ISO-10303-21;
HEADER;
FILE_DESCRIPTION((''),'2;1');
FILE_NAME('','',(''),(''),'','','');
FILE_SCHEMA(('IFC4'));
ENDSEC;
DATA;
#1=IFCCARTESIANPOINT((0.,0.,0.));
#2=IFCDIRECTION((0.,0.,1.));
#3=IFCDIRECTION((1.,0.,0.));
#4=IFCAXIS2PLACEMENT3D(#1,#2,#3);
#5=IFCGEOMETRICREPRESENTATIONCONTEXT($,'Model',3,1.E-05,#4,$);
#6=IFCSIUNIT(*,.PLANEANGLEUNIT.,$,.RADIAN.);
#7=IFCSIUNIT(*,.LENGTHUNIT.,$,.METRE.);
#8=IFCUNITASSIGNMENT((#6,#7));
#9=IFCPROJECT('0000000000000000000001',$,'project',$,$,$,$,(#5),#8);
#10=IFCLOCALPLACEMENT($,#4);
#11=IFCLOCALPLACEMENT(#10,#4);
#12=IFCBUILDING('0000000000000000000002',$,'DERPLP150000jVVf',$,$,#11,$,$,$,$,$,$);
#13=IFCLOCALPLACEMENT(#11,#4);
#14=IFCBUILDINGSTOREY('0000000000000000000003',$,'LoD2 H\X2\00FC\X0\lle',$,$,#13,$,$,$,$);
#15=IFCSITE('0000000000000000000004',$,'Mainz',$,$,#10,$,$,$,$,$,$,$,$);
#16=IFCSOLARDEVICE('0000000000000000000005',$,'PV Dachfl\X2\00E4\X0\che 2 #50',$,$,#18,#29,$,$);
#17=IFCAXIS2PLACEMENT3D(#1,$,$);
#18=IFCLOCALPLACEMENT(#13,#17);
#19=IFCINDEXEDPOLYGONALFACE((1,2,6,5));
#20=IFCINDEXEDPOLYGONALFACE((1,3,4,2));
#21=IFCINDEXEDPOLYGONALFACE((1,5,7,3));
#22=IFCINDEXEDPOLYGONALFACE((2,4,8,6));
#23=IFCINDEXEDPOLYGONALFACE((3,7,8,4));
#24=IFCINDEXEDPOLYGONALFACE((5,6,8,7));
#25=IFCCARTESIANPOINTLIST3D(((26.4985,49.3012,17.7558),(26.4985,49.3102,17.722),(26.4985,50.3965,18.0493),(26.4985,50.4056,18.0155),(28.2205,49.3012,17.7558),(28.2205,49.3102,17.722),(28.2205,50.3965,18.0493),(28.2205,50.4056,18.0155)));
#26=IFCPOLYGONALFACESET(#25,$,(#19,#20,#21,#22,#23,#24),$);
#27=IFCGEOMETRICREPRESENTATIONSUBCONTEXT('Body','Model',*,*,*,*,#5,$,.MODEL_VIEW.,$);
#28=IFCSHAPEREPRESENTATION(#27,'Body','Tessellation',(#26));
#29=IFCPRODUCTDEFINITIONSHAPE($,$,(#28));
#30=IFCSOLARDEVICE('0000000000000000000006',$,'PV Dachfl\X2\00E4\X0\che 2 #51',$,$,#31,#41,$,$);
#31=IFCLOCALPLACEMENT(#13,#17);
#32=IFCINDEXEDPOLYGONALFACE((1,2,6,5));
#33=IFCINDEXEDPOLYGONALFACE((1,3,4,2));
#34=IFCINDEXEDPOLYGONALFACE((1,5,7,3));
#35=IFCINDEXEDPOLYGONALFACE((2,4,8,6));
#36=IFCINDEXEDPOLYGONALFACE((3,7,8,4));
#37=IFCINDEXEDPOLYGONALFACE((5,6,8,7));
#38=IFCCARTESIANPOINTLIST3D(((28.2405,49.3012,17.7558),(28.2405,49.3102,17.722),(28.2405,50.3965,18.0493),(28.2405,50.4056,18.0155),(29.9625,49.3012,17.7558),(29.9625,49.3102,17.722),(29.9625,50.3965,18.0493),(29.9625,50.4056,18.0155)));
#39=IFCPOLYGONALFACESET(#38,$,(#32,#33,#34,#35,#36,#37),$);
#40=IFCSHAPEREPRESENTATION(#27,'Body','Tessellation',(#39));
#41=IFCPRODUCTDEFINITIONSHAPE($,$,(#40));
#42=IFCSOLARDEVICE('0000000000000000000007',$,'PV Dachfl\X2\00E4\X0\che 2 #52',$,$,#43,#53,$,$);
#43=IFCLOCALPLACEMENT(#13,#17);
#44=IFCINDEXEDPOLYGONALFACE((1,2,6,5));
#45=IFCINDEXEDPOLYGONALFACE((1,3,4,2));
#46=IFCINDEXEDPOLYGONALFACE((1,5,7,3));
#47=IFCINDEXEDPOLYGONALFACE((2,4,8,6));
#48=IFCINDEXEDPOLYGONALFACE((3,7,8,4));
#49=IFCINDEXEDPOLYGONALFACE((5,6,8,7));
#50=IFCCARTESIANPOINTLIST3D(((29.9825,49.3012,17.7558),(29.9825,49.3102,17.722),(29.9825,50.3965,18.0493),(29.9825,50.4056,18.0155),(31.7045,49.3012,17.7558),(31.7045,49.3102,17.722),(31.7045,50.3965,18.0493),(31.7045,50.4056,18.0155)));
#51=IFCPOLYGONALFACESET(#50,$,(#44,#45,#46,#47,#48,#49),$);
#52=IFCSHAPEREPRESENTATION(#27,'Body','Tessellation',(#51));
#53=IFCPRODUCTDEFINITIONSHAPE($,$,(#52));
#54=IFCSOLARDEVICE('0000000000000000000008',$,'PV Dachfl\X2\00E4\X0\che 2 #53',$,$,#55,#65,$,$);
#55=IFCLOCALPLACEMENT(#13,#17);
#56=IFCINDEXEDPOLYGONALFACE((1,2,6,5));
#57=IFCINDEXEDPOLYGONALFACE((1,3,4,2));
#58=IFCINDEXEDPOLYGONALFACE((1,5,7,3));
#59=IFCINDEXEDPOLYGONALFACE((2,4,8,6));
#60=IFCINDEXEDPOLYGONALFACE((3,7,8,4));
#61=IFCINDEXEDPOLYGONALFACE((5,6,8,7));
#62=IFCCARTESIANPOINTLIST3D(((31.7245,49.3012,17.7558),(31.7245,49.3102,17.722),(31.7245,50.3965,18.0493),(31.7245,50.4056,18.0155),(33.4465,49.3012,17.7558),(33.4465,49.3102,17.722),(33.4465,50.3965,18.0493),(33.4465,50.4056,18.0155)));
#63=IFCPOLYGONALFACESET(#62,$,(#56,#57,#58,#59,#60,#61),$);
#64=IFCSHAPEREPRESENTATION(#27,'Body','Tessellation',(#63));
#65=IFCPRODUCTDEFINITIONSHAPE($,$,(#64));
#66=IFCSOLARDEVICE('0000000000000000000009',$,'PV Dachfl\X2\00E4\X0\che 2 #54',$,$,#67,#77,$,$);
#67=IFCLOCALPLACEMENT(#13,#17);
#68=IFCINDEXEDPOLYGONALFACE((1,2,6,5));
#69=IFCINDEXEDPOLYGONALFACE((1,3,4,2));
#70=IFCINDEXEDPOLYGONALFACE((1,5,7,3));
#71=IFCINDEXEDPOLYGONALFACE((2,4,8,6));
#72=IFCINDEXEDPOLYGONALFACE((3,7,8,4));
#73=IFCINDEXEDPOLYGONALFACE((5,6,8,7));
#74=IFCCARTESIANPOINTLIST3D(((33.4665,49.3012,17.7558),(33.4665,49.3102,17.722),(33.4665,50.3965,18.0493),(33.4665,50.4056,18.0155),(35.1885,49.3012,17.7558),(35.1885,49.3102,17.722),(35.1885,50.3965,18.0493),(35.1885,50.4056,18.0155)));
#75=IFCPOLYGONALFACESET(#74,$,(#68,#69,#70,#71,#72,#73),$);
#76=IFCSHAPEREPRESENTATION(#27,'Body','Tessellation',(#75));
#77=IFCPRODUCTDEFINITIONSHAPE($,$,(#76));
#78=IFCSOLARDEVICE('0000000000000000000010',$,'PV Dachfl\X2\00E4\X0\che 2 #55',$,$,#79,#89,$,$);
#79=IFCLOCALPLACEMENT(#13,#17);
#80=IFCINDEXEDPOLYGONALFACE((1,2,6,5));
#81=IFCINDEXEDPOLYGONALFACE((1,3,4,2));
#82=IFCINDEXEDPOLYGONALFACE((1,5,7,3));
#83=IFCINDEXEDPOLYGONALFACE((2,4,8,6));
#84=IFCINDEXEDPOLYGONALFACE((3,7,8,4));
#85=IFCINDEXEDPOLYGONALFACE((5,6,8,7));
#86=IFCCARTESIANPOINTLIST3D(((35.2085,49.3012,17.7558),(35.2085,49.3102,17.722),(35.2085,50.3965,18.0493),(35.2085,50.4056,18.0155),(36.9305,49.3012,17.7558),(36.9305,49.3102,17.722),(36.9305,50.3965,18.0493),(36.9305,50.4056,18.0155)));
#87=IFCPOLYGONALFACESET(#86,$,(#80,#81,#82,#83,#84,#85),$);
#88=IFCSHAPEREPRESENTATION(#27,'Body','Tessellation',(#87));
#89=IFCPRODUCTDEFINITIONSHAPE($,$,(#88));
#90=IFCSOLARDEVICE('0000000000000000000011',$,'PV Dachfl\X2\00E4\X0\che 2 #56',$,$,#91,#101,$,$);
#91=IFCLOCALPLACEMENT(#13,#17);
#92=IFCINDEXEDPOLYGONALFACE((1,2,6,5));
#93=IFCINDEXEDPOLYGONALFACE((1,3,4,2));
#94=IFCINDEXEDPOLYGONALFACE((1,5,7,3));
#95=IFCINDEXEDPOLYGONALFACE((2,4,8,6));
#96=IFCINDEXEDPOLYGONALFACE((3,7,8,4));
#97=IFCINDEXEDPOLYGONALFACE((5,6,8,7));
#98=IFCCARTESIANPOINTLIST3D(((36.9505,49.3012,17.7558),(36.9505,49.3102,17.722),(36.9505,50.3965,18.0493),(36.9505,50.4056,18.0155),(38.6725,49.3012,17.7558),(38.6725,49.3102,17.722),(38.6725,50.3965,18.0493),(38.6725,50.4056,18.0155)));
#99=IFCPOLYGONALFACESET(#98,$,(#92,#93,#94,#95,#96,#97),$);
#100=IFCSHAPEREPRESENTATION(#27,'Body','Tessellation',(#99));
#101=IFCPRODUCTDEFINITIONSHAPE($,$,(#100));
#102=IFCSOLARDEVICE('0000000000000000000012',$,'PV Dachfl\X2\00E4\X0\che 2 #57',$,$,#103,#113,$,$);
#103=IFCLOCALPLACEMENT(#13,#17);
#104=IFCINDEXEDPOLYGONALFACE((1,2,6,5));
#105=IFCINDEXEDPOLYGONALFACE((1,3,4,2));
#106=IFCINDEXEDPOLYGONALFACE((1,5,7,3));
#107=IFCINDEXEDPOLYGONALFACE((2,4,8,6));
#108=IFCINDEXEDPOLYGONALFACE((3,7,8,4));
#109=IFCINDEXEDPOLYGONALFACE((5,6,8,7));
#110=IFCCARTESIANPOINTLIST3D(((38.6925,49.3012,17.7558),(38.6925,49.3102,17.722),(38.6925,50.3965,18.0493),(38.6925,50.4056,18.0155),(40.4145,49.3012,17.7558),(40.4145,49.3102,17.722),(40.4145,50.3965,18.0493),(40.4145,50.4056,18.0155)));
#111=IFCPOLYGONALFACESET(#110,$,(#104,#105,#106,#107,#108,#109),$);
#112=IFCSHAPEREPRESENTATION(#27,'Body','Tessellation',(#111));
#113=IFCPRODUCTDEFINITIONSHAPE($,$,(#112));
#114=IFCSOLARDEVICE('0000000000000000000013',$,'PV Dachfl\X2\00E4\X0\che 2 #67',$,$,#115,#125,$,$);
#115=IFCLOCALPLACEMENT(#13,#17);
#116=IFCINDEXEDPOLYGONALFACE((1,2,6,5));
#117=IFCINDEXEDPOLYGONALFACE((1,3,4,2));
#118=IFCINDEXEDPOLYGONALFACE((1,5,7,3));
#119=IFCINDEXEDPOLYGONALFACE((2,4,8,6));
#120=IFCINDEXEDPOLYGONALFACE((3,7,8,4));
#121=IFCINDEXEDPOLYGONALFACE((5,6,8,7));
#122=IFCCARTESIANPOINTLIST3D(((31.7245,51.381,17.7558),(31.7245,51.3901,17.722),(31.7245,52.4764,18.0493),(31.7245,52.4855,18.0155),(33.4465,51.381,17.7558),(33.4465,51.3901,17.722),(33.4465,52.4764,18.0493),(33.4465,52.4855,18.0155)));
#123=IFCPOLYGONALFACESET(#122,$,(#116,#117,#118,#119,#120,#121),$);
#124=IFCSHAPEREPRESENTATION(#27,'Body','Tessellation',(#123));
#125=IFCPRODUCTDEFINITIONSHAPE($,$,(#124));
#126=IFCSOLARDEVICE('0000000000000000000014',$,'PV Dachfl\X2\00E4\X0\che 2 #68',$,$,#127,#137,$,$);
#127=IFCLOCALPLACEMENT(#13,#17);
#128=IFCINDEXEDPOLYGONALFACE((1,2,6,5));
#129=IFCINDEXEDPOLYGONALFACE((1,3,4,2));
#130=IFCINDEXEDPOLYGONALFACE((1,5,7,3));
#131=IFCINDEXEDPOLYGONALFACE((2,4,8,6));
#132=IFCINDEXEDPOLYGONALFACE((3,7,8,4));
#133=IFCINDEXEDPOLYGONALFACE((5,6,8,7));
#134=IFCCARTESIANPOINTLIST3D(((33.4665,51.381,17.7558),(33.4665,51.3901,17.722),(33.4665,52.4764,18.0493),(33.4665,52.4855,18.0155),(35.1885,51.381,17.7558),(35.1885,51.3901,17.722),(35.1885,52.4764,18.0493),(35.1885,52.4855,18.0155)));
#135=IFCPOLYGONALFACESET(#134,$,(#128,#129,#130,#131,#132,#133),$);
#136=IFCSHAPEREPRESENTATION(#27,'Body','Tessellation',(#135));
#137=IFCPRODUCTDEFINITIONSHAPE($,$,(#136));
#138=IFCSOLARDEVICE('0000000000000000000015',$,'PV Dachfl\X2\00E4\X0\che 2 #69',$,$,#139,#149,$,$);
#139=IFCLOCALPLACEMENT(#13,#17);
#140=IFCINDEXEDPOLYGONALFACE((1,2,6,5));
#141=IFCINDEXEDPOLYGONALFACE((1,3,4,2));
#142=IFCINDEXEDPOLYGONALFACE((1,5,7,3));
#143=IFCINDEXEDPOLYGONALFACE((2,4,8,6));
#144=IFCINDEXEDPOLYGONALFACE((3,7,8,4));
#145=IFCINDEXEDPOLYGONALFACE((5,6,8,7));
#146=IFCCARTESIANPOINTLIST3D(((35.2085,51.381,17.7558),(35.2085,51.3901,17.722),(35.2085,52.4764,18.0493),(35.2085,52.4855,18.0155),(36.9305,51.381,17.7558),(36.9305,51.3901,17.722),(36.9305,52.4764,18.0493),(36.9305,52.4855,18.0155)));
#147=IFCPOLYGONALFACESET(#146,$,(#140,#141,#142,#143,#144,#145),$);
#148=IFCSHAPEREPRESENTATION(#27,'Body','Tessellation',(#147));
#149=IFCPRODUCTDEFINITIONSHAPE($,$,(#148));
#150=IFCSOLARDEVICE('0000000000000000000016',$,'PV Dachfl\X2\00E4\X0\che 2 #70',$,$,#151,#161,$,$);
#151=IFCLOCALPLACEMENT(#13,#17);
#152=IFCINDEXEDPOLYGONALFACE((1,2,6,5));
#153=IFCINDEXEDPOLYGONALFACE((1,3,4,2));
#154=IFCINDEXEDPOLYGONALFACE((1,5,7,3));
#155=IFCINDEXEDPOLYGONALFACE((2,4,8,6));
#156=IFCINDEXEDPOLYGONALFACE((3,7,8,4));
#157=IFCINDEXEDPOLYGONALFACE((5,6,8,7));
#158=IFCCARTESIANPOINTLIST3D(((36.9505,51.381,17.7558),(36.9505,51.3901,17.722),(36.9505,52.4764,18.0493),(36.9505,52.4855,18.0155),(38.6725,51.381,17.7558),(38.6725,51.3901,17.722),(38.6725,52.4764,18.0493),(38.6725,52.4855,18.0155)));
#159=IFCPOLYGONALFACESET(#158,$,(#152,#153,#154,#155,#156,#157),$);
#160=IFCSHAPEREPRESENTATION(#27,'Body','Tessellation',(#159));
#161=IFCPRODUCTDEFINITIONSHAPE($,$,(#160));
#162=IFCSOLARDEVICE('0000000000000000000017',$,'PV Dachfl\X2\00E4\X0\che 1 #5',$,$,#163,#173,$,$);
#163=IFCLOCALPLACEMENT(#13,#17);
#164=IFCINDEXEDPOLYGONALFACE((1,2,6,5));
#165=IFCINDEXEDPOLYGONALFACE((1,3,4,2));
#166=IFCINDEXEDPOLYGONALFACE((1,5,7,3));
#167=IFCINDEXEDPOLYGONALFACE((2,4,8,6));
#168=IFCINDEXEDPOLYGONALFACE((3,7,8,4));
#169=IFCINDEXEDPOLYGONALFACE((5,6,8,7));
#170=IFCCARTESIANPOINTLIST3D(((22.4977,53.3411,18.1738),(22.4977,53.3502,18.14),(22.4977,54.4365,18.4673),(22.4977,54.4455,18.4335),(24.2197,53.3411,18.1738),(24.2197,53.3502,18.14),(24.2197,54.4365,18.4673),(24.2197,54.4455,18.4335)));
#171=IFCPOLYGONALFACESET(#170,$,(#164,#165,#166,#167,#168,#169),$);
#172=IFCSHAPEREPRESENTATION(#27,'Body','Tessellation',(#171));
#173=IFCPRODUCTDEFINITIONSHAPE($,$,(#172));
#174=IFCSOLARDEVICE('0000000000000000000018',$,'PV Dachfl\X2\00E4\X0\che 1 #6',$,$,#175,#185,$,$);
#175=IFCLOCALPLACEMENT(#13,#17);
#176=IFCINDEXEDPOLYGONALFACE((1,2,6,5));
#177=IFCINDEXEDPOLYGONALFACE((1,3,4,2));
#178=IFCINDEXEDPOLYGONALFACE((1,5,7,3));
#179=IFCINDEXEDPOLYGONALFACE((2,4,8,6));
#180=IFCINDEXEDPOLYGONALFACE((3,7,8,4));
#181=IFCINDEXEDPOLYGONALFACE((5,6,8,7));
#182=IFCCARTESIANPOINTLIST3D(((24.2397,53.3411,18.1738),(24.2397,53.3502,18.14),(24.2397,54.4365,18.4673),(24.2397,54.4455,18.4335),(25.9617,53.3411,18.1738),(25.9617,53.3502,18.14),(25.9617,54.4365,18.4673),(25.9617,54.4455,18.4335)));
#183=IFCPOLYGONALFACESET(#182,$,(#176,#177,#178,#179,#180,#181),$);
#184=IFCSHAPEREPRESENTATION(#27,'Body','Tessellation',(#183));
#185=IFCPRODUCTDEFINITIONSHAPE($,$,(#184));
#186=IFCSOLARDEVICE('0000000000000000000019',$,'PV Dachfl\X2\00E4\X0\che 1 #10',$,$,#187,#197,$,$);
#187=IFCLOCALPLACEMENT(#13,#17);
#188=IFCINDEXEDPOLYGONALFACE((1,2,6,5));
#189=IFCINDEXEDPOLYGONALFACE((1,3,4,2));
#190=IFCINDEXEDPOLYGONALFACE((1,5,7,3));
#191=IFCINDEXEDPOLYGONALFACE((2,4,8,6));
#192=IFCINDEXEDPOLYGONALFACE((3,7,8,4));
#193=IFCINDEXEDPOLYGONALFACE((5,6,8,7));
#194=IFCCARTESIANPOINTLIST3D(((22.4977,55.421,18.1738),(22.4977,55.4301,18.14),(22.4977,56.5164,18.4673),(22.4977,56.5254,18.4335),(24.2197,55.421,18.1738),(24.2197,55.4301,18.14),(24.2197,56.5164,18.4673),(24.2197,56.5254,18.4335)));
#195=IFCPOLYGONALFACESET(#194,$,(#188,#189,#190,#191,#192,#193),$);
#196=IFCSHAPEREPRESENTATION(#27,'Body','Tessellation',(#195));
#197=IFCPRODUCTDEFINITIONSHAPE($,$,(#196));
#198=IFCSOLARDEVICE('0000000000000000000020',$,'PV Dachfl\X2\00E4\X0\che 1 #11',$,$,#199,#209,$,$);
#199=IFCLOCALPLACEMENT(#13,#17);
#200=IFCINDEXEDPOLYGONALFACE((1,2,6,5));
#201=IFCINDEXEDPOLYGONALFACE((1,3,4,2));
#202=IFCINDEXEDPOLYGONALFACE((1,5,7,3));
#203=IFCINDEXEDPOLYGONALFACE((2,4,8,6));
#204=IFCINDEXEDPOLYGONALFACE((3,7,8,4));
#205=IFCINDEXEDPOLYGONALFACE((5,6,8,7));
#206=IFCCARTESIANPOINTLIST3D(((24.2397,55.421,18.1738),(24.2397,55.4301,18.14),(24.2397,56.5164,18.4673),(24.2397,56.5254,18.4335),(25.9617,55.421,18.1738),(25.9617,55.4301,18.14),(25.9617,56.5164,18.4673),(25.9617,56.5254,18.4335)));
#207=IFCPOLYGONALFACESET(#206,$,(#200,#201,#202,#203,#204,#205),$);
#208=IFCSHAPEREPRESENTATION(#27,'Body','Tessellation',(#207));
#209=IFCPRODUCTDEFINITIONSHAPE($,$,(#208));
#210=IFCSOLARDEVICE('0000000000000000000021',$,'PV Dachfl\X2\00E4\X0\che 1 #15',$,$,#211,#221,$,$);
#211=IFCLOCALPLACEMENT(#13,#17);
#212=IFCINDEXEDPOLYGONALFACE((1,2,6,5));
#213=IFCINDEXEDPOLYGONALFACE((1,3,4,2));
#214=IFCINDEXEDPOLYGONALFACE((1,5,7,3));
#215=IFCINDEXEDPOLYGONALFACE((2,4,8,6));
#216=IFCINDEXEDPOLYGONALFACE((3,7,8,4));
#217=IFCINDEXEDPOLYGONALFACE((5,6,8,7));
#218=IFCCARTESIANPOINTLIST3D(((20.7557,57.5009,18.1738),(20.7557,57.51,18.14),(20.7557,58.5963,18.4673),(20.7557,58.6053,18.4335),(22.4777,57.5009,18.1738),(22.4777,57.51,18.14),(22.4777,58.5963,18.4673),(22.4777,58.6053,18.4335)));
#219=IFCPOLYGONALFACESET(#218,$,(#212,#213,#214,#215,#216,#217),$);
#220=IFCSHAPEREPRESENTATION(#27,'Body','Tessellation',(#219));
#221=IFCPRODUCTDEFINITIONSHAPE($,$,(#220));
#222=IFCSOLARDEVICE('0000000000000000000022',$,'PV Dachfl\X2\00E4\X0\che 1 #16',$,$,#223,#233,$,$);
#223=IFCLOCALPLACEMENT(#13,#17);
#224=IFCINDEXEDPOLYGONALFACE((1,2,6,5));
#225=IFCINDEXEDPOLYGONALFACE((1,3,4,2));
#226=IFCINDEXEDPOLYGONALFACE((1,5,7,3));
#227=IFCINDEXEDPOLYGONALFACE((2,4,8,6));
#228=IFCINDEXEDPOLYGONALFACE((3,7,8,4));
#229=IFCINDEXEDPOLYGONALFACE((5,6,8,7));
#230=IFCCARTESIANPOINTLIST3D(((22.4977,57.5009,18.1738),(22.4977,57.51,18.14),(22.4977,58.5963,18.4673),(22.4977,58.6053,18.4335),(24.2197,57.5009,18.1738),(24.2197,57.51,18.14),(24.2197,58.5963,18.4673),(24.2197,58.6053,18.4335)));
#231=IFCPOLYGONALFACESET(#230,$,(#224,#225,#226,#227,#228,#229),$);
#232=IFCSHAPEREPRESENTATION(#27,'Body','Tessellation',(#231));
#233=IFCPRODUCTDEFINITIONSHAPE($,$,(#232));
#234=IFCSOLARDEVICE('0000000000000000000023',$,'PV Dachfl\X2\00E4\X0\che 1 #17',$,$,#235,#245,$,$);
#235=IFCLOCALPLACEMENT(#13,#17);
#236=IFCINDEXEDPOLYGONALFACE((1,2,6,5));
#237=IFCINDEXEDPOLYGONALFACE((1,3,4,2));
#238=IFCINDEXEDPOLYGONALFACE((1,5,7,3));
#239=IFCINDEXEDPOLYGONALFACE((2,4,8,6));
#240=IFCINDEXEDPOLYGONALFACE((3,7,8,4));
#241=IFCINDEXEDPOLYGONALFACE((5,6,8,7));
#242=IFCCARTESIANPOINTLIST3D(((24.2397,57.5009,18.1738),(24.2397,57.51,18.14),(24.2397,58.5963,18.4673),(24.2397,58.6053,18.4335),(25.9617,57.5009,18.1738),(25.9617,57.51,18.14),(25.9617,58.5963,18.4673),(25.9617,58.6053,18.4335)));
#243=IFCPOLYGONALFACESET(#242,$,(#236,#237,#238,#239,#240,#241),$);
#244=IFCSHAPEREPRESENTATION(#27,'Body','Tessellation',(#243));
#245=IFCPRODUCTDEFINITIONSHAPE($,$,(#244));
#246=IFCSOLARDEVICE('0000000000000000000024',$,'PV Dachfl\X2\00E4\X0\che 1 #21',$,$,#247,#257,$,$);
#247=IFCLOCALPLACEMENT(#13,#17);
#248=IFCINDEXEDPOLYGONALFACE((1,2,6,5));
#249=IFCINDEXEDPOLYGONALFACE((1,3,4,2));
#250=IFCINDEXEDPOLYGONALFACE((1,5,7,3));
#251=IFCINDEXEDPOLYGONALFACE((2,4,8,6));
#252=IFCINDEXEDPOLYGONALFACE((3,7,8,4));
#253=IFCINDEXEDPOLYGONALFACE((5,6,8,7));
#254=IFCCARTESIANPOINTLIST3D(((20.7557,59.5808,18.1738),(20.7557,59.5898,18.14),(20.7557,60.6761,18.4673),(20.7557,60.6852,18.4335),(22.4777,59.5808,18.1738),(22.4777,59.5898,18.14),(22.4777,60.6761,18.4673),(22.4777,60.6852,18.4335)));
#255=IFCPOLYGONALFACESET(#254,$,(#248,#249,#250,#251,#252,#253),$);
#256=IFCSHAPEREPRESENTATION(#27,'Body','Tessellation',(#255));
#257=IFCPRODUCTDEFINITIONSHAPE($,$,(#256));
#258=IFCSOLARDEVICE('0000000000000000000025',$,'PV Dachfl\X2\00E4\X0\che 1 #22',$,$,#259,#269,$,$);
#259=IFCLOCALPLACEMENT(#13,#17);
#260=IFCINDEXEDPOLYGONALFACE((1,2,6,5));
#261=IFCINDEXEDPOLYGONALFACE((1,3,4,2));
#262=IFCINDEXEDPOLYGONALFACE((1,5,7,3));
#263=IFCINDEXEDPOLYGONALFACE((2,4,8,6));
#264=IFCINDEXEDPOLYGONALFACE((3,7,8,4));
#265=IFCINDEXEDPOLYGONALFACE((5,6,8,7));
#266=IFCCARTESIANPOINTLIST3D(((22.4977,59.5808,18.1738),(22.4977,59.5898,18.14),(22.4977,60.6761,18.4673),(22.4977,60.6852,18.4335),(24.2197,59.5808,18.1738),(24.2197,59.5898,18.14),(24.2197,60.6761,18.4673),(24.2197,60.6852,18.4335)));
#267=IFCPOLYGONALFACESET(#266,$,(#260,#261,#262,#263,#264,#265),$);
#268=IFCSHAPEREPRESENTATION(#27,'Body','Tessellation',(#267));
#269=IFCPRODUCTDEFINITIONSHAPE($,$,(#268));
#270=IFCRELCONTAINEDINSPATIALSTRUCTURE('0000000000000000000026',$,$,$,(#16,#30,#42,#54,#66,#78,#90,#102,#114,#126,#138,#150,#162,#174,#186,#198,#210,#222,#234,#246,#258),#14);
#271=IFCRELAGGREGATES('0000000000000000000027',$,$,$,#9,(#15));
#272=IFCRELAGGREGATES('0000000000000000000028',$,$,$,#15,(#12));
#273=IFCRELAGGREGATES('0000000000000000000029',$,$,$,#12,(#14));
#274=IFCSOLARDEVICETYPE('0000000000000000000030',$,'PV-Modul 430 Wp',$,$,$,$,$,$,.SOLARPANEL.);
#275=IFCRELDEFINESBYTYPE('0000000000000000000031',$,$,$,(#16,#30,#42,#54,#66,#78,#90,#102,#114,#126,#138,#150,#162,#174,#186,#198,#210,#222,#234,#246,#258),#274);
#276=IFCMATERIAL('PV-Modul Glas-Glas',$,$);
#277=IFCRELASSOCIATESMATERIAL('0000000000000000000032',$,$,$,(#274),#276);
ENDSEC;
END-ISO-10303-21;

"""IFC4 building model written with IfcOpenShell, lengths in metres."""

from ifc_helpers import new_model, si_unit, frame, frame_2d, origin, origin_with_axes, place, context, subcontext, project, spatial, rectangle, extrude, source, transform, mapped, material, type_object, type_shapes, element, save


model = new_model("IFC4")

# Units and contexts
model_context = context("Model", 3, precision=1e-05, world=origin_with_axes())
body_context = subcontext(model_context, "Body", "Model", "MODEL_VIEW")
ifc_project = project(units=[si_unit("PLANEANGLEUNIT", "RADIAN"), si_unit("LENGTHUNIT", "METRE")], contexts=[model_context])

# Site, building, storey
site_placement = place(None, origin_with_axes())
site = spatial("IfcSite", under=ifc_project, at=site_placement, Name="Mainz")
building_placement = place(site_placement, origin_with_axes())
building = spatial("IfcBuilding", under=site, at=building_placement, Name="DERPLP150000jVVf")
storey_placement = place(building_placement, origin_with_axes())
storey = spatial("IfcBuildingStorey", under=building, at=storey_placement, Name="LoD2 Hülle")

# Solar devices
ifc_material = material(Name="PV-Modul Glas-Glas")
solar_device_type = type_object("IfcSolarDeviceType", Name="PV-Modul 430 Wp", PredefinedType="SOLARPANEL", material=ifc_material)
shared_shape = source(origin_with_axes(), body_context, "Body", "SweptSolid", [
    extrude(rectangle(XDim=1.722, YDim=1.134, at=frame_2d((0.861, 0.567))), origin(), (0.0, 0.0, 1.0), 0.035),
])
type_shapes(solar_device_type, [shared_shape])
for number, where, z_axis, x_axis, name in (
    (1, (26.4985, 49.3102, 17.722), (0.0, -0.258819, 0.965926), (1.0, 0.0, 0.0), "PV Dachfläche 2 #50"),
    (2, (28.2405, 49.3102, 17.722), (0.0, -0.258819, 0.965926), (1.0, 0.0, 0.0), "PV Dachfläche 2 #51"),
    (3, (29.9825, 49.3102, 17.722), (0.0, -0.258819, 0.965926), (1.0, 0.0, 0.0), "PV Dachfläche 2 #52"),
    (4, (31.7245, 49.3102, 17.722), (0.0, -0.258819, 0.965926), (1.0, 0.0, 0.0), "PV Dachfläche 2 #53"),
    (5, (33.4665, 49.3102, 17.722), (0.0, -0.258819, 0.965926), (1.0, 0.0, 0.0), "PV Dachfläche 2 #54"),
    (6, (35.2085, 49.3102, 17.722), (0.0, -0.258819, 0.965926), (1.0, 0.0, 0.0), "PV Dachfläche 2 #55"),
    (7, (36.9505, 49.3102, 17.722), (0.0, -0.258819, 0.965926), (1.0, 0.0, 0.0), "PV Dachfläche 2 #56"),
    (8, (38.6925, 49.3102, 17.722), (0.0, -0.258819, 0.965926), (1.0, 0.0, 0.0), "PV Dachfläche 2 #57"),
    (9, (31.7245, 51.3901, 17.722), (0.0, -0.258819, 0.965926), (1.0, 0.0, 0.0), "PV Dachfläche 2 #67"),
    (10, (33.4665, 51.3901, 17.722), (0.0, -0.258819, 0.965926), (1.0, 0.0, 0.0), "PV Dachfläche 2 #68"),
    (11, (35.2085, 51.3901, 17.722), (0.0, -0.258819, 0.965926), (1.0, 0.0, 0.0), "PV Dachfläche 2 #69"),
    (12, (36.9505, 51.3901, 17.722), (0.0, -0.258819, 0.965926), (1.0, 0.0, 0.0), "PV Dachfläche 2 #70"),
    (13, (22.4977, 53.3502, 18.14), (0.0, -0.258819, 0.965926), (1.0, 0.0, 0.0), "PV Dachfläche 1 #5"),
    (14, (24.2397, 53.3502, 18.14), (0.0, -0.258819, 0.965926), (1.0, 0.0, 0.0), "PV Dachfläche 1 #6"),
    (15, (22.4977, 55.4301, 18.14), (0.0, -0.258819, 0.965926), (1.0, 0.0, 0.0), "PV Dachfläche 1 #10"),
    (16, (24.2397, 55.4301, 18.14), (0.0, -0.258819, 0.965926), (1.0, 0.0, 0.0), "PV Dachfläche 1 #11"),
    (17, (20.7557, 57.51, 18.14), (0.0, -0.258819, 0.965926), (1.0, 0.0, 0.0), "PV Dachfläche 1 #15"),
    (18, (22.4977, 57.51, 18.14), (0.0, -0.258819, 0.965926), (1.0, 0.0, 0.0), "PV Dachfläche 1 #16"),
    (19, (24.2397, 57.51, 18.14), (0.0, -0.258819, 0.965926), (1.0, 0.0, 0.0), "PV Dachfläche 1 #17"),
    (20, (20.7557, 59.5898, 18.14), (0.0, -0.258819, 0.965926), (1.0, 0.0, 0.0), "PV Dachfläche 1 #21"),
    (21, (22.4977, 59.5898, 18.14), (0.0, -0.258819, 0.965926), (1.0, 0.0, 0.0), "PV Dachfläche 1 #22"),
):
    element("IfcSolarDevice", number, at=place(storey_placement, frame(where, z_axis=z_axis, x_axis=x_axis)), inside=storey, type_object=solar_device_type, Name=name, context=body_context, shape_type="MappedRepresentation", body=[
        mapped(shared_shape, transform((0.0, 0.0, 0.0), x_axis=(1.0, 0.0, 0.0), y_axis=(0.0, 1.0, 0.0), z_axis=(0.0, 0.0, 1.0), scale=1.0)),
    ])

save(model, "model.ifc")
